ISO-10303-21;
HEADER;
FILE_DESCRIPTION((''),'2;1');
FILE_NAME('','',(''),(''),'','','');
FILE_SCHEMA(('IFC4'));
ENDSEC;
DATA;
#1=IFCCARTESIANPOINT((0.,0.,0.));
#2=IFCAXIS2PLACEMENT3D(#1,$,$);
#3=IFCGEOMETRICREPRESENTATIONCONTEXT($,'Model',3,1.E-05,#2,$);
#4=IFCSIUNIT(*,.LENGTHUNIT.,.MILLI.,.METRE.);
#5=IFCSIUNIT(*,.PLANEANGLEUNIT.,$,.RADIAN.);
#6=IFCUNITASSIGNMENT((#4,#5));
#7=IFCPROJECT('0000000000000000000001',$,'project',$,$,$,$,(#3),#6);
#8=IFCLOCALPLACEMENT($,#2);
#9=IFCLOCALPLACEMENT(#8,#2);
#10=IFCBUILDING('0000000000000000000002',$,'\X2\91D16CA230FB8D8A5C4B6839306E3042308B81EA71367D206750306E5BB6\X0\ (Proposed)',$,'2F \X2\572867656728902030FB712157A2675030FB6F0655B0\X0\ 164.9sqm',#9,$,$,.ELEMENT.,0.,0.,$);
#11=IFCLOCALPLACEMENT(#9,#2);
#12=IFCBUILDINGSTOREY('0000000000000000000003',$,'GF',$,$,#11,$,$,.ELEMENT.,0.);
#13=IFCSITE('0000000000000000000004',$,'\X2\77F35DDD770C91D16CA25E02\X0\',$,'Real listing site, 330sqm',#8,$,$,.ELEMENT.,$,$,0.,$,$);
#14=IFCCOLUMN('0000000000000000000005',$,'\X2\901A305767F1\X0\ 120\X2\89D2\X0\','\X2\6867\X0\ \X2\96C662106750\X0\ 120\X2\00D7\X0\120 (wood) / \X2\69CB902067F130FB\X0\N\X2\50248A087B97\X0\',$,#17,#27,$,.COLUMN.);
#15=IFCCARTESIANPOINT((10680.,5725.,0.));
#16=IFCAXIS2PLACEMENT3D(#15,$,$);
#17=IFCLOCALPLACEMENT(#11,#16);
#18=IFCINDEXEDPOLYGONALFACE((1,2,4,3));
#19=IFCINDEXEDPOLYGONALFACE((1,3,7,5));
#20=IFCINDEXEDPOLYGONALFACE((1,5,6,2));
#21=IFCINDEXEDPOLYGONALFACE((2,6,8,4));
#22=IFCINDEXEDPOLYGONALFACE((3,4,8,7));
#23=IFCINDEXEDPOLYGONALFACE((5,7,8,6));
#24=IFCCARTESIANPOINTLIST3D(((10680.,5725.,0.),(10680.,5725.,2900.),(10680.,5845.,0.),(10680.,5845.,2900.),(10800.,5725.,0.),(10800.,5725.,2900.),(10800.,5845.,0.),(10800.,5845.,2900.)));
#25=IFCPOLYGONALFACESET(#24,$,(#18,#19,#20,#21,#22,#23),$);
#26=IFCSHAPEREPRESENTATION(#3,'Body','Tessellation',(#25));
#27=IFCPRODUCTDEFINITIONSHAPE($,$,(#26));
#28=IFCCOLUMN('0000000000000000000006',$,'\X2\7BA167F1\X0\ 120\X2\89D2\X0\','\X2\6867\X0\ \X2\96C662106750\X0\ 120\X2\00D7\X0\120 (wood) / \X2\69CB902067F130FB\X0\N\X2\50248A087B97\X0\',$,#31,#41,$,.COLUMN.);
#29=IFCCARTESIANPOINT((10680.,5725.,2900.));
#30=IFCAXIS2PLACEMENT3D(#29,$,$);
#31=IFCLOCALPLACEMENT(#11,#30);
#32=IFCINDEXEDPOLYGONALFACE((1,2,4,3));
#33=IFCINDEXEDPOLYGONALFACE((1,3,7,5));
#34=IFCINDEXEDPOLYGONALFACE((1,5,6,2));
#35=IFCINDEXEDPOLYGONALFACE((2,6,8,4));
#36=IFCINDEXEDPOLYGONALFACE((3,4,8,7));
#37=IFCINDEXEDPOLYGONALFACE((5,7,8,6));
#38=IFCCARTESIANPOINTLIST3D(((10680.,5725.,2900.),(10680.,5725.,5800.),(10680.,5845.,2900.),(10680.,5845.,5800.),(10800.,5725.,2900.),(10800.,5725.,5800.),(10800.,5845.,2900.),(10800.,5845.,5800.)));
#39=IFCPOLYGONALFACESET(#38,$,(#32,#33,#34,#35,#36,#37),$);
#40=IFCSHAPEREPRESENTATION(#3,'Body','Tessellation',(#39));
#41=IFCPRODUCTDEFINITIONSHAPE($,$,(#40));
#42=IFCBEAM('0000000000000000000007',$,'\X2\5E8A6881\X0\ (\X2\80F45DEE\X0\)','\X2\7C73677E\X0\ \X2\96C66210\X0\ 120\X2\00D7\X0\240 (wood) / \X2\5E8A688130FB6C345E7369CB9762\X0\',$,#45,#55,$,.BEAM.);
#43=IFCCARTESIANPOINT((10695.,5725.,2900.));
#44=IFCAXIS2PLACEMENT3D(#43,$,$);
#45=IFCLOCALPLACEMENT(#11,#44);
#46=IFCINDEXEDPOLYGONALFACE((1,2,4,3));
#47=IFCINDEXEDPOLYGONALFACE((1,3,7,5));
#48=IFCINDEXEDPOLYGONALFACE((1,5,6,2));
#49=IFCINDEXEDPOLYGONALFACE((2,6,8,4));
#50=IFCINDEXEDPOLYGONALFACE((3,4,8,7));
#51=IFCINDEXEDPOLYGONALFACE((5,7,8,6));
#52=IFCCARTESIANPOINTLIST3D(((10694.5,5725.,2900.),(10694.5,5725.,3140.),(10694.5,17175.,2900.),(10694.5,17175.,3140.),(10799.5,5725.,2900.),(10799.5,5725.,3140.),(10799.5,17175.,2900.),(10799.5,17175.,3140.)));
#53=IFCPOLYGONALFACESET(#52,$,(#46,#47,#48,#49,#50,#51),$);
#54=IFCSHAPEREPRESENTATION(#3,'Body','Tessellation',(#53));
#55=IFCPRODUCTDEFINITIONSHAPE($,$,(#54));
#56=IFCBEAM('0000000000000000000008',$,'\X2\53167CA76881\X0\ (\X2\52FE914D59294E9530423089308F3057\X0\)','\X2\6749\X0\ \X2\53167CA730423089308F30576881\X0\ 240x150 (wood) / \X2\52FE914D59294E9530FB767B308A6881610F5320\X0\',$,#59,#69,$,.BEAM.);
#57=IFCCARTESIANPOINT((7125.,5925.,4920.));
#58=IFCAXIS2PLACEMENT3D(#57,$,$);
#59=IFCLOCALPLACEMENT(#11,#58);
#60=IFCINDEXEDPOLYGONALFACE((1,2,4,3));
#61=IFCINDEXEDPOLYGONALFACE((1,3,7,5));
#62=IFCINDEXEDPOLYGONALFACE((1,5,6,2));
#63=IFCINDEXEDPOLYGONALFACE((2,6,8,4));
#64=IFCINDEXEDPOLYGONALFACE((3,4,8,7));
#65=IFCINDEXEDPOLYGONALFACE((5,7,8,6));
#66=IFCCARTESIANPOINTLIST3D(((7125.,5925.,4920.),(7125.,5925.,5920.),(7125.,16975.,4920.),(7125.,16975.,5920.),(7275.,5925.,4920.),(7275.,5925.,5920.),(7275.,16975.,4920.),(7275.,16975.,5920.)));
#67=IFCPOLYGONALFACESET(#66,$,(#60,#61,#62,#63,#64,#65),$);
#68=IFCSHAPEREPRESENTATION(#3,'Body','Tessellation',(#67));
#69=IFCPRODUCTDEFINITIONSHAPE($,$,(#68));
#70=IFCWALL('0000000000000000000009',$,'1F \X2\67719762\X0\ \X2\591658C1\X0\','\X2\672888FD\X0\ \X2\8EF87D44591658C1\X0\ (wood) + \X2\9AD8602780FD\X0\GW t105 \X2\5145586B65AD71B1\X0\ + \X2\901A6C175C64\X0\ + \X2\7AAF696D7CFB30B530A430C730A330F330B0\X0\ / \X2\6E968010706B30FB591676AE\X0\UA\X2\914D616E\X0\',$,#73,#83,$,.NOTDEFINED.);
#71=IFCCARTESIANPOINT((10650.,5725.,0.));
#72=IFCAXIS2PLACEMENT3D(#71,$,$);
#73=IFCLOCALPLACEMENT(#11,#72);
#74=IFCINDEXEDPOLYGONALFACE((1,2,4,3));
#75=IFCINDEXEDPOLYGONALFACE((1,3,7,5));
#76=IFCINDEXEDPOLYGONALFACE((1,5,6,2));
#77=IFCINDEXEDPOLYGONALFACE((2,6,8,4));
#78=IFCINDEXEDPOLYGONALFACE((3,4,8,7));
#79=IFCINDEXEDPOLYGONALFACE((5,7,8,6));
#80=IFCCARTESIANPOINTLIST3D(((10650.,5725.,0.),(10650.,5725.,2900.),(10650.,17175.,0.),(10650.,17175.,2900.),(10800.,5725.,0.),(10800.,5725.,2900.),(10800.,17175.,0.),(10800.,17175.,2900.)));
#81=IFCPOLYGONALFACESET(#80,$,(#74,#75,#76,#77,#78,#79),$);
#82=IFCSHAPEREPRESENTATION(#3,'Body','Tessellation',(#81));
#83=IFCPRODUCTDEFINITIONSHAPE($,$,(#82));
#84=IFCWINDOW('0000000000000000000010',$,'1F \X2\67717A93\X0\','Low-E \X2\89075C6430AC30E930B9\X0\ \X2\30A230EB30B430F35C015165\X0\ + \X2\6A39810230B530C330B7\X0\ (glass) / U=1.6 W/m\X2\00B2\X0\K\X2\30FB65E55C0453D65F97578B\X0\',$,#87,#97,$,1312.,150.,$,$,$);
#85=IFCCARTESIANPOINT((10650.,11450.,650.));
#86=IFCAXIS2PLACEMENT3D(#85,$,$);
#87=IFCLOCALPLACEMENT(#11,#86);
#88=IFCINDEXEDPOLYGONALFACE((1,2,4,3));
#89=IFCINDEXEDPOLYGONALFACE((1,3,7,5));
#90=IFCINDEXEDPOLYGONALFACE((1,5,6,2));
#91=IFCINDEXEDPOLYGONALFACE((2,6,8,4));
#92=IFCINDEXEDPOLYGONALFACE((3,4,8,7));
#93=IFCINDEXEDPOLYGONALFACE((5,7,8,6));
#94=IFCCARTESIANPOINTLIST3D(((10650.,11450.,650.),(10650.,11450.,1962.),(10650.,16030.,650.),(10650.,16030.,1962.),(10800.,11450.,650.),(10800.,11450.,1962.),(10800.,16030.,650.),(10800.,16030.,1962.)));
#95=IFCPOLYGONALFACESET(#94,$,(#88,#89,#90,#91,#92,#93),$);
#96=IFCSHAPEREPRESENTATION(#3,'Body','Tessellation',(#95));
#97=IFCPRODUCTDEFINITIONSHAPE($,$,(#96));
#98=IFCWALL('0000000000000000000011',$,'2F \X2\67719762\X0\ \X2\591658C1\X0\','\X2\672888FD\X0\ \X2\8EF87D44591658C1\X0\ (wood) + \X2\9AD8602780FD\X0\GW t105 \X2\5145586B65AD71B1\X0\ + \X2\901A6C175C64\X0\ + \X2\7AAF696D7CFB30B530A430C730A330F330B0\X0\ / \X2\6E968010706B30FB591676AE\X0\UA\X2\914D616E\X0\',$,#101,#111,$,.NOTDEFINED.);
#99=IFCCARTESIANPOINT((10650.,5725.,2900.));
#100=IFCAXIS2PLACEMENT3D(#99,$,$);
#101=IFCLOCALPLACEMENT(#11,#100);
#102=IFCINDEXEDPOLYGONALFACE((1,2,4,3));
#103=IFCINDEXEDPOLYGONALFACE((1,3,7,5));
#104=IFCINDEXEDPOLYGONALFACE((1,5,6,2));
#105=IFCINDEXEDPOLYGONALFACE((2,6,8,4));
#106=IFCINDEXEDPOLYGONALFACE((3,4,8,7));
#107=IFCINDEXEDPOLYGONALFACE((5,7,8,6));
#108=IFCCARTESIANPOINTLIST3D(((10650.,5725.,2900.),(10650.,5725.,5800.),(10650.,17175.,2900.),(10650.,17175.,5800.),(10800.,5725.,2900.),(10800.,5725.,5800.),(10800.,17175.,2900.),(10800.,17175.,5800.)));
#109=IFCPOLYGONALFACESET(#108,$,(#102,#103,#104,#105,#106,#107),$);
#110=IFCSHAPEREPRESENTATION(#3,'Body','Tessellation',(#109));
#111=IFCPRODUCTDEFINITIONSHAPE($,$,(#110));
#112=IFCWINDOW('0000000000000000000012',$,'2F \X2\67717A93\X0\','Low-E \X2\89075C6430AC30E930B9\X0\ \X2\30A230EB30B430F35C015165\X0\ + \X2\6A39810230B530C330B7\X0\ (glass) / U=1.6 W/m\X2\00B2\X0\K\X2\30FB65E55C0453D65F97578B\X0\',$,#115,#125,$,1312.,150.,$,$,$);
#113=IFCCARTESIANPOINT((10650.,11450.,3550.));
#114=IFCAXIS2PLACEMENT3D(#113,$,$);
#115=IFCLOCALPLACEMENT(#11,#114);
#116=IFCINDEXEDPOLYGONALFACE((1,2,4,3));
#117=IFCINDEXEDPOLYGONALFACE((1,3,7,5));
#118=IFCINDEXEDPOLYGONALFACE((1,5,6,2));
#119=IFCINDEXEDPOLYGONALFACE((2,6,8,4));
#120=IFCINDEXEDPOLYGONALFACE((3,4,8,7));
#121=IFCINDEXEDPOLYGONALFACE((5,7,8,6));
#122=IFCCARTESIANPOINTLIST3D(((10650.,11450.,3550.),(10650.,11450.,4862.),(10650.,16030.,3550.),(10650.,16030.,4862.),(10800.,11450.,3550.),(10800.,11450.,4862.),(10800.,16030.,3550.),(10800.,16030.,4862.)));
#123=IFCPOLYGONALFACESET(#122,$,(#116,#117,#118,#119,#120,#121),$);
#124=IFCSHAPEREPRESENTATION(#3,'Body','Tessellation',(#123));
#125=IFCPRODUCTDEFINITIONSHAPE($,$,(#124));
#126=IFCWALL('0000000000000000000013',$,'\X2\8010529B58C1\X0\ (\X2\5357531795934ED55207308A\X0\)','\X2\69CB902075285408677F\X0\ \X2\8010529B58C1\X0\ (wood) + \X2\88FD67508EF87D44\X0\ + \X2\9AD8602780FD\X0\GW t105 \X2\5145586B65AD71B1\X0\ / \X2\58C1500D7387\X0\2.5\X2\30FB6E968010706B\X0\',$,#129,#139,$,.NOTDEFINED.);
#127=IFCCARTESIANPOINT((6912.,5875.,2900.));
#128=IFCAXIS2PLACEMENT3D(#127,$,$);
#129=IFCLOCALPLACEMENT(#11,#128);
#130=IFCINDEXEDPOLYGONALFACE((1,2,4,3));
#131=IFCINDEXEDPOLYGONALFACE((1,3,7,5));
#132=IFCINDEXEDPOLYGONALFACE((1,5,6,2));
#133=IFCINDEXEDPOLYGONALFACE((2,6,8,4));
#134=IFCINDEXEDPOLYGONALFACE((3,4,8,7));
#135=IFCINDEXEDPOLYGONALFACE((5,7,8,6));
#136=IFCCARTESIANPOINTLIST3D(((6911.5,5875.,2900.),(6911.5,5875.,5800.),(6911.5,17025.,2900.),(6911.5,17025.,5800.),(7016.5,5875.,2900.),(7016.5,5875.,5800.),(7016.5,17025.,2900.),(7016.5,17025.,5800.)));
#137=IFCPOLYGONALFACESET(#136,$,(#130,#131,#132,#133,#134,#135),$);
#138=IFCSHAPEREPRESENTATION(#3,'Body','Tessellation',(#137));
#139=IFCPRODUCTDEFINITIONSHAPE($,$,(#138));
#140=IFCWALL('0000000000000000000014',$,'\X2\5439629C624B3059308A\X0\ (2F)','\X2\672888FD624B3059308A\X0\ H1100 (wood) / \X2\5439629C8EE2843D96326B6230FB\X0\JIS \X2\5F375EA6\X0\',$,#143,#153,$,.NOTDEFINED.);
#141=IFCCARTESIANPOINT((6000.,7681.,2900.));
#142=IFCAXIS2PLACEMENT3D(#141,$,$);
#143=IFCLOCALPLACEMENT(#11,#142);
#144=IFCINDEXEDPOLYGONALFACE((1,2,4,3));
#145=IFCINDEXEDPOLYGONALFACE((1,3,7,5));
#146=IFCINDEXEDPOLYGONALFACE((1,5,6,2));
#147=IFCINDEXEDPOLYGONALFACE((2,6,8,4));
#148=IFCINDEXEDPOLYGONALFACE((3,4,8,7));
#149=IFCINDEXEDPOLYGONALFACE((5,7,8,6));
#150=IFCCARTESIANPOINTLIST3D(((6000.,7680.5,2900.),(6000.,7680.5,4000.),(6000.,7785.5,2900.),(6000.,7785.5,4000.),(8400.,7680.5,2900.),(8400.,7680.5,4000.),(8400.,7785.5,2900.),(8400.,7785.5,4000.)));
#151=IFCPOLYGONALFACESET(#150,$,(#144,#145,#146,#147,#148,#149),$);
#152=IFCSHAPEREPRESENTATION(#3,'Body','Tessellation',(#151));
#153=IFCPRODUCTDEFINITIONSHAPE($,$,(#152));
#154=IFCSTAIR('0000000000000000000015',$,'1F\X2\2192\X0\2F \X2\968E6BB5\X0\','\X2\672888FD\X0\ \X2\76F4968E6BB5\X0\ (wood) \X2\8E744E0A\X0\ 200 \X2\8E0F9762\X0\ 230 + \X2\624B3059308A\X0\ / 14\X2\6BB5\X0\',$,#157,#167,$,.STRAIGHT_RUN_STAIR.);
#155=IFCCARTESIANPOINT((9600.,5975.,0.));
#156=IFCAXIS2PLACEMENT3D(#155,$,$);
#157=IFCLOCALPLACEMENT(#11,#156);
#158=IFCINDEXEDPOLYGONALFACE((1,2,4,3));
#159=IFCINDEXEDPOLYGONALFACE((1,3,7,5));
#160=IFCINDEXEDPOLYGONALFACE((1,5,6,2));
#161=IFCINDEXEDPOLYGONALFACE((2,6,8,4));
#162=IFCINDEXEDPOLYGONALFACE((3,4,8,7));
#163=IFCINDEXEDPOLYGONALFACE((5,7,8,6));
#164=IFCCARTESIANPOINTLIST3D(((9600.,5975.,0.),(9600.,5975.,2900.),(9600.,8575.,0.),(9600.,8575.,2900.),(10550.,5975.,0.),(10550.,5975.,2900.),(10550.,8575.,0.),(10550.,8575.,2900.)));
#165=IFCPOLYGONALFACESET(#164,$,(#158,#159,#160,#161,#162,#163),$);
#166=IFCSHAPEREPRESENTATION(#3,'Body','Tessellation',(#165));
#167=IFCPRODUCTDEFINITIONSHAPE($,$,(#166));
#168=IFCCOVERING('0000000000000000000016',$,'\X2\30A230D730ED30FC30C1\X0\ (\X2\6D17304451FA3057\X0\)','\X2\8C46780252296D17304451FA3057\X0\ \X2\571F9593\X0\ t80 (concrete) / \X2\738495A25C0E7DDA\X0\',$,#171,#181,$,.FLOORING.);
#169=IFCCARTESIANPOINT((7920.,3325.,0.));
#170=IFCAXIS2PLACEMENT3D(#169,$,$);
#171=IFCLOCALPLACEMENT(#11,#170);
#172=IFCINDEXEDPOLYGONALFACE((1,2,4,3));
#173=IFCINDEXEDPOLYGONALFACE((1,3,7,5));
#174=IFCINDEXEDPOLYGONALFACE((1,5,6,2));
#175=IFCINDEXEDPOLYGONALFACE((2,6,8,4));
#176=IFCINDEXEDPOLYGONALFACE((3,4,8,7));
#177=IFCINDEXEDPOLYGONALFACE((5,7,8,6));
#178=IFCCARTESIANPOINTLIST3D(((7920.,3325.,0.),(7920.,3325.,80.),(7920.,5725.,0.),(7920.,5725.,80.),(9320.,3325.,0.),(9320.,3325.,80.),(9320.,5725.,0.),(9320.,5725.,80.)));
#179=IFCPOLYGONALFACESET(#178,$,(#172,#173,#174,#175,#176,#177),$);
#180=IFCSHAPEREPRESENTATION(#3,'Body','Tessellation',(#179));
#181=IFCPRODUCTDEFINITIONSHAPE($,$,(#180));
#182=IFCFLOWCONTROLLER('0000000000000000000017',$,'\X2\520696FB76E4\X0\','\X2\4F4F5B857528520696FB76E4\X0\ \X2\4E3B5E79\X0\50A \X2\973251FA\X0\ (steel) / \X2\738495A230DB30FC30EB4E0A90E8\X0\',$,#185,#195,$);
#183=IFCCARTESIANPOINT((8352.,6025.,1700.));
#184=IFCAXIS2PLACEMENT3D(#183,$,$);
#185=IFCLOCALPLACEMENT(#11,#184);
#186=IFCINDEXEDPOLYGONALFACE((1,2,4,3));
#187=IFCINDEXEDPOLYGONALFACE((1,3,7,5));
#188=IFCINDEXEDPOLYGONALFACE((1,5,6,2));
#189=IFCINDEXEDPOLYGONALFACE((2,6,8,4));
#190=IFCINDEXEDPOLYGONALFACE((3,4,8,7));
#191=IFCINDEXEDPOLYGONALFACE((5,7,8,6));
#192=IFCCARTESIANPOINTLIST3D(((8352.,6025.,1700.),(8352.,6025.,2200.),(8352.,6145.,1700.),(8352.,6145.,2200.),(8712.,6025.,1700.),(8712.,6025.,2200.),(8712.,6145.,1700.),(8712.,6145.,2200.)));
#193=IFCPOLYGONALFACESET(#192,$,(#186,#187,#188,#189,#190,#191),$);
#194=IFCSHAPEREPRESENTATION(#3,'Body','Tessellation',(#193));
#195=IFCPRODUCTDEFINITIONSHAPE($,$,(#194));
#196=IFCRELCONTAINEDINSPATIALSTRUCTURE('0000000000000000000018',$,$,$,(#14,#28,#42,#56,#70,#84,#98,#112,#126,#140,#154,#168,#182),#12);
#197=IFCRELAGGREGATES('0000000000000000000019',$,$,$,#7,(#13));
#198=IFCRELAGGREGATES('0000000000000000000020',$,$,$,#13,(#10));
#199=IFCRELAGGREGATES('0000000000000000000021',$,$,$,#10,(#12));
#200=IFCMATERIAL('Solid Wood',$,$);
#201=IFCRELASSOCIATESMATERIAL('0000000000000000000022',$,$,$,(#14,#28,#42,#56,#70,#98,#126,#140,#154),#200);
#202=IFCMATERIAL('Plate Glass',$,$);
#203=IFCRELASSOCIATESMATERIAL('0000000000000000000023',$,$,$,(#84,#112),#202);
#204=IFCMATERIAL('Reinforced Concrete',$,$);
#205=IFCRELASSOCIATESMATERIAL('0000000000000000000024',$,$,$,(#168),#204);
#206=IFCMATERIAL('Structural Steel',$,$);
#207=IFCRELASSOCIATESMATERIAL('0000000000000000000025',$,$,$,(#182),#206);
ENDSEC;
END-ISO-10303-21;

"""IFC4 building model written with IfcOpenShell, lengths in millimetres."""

from ifc_helpers import new_model, si_unit, frame, frame_2d, origin, place, context, project, spatial, rectangle, extrude, material, element, fill, save


model = new_model("IFC4")

# Units and contexts
model_context = context("Model", 3, precision=1e-05, world=origin())
ifc_project = project(units=[si_unit("LENGTHUNIT", "METRE", prefix="MILLI"), si_unit("PLANEANGLEUNIT", "RADIAN")], contexts=[model_context])

# Site, building, storey
site_placement = place(None, origin())
site = spatial("IfcSite", under=ifc_project, at=site_placement, Name="石川県金沢市", ObjectType="Real listing site, 330sqm", CompositionType="ELEMENT", RefElevation=0.0)
building_placement = place(site_placement, origin())
building = spatial("IfcBuilding", under=site, at=building_placement, Name="金沢・越屋根のある自然素材の家 (Proposed)", ObjectType="2F 在来木造・無垢材・漆喰 164.9sqm", CompositionType="ELEMENT", ElevationOfRefHeight=0.0, ElevationOfTerrain=0.0)
storey_placement = place(building_placement, origin())
storey = spatial("IfcBuildingStorey", under=building, at=storey_placement, Name="GF", CompositionType="ELEMENT", Elevation=0.0)

# Columns
ifc_material_1 = material(Name="Solid Wood")
column_1_placement = place(storey_placement, frame((10680.0, 5725.0, 0.0)))
element("IfcColumn", 1, at=column_1_placement, inside=storey, material=ifc_material_1, Name="通し柱 120角", Description="桧 集成材 120×120 (wood) / 構造柱・N値計算", PredefinedType="COLUMN", context=model_context, shape_type="SweptSolid", body=[
    extrude(rectangle(XDim=120.0, YDim=120.0, at=frame_2d((60.0, 60.0))), frame((10680.0, 5725.0, 0.0)), (0.0, 0.0, 1.0), 2900.0),
])
column_2_placement = place(storey_placement, frame((10680.0, 5725.0, 2900.0)))
element("IfcColumn", 2, at=column_2_placement, inside=storey, material=ifc_material_1, Name="管柱 120角", Description="桧 集成材 120×120 (wood) / 構造柱・N値計算", PredefinedType="COLUMN", context=model_context, shape_type="SweptSolid", body=[
    extrude(rectangle(XDim=120.0, YDim=120.0, at=frame_2d((60.0, 60.0))), frame((10680.0, 5725.0, 2900.0)), (0.0, 0.0, 1.0), 2900.0),
])

# Beams
beam_1_placement = place(storey_placement, frame((10695.0, 5725.0, 2900.0)))
element("IfcBeam", 3, at=beam_1_placement, inside=storey, material=ifc_material_1, Name="床梁 (胴差)", Description="米松 集成 120×240 (wood) / 床梁・水平構面", PredefinedType="BEAM", context=model_context, shape_type="SweptSolid", body=[
    extrude(rectangle(XDim=105.0, YDim=11450.0, at=frame_2d((52.0, 5725.0))), frame((10695.0, 5725.0, 2900.0)), (0.0, 0.0, 1.0), 240.0),
])
beam_2_placement = place(storey_placement, frame((7125.0, 5925.0, 4920.0)))
element("IfcBeam", 4, at=beam_2_placement, inside=storey, material=ifc_material_1, Name="化粧梁 (勾配天井あらわし)", Description="杉 化粧あらわし梁 240x150 (wood) / 勾配天井・登り梁意匠", PredefinedType="BEAM", context=model_context, shape_type="SweptSolid", body=[
    extrude(rectangle(XDim=150.0, YDim=11050.0, at=frame_2d((75.0, 5525.0))), frame((7125.0, 5925.0, 4920.0)), (0.0, 0.0, 1.0), 1000.0),
])

# Wall, opening, window
wall_1_placement = place(storey_placement, frame((10650.0, 5725.0, 0.0)))
wall_1 = element("IfcWall", 5, at=wall_1_placement, inside=storey, material=ifc_material_1, Name="1F 東面 外壁", Description="木製 軸組外壁 (wood) + 高性能GW t105 充填断熱 + 通気層 + 窯業系サイディング / 準耐火・外皮UA配慮", PredefinedType="NOTDEFINED", context=model_context, shape_type="SweptSolid", body=[
    extrude(rectangle(XDim=150.0, YDim=11450.0, at=frame_2d((75.0, 5725.0))), frame((10650.0, 5725.0, 0.0)), (0.0, 0.0, 1.0), 2900.0),
])
opening_1_placement = place(storey_placement, frame((10650.0, 11450.0, 650.0)))
opening_1 = element("IfcOpeningElement", 6, at=opening_1_placement, cuts=wall_1, PredefinedType="NOTDEFINED", context=model_context, shape_type="SweptSolid", body=[
    extrude(rectangle(XDim=150.0, YDim=4580.0, at=frame_2d((75.0, 2290.0))), frame((10650.0, 11450.0, 650.0)), (0.0, 0.0, 1.0), 1312.0),
])
ifc_material_2 = material(Name="Plate Glass")
window_1_placement = place(storey_placement, frame((10650.0, 11450.0, 650.0)))
window_1 = element("IfcWindow", 7, at=window_1_placement, inside=storey, material=ifc_material_2, Name="1F 東窓", Description="Low-E 複層ガラス アルゴン封入 + 樹脂サッシ (glass) / U=1.6 W/m²K・日射取得型", OverallHeight=1312.0, OverallWidth=150.0, context=model_context, shape_type="SweptSolid", body=[
    extrude(rectangle(XDim=150.0, YDim=4580.0, at=frame_2d((75.0, 2290.0))), frame((10650.0, 11450.0, 650.0)), (0.0, 0.0, 1.0), 1312.0),
])
fill(opening_1, window_1)

# Wall, opening, window
wall_2_placement = place(storey_placement, frame((10650.0, 5725.0, 2900.0)))
wall_2 = element("IfcWall", 8, at=wall_2_placement, inside=storey, material=ifc_material_1, Name="2F 東面 外壁", Description="木製 軸組外壁 (wood) + 高性能GW t105 充填断熱 + 通気層 + 窯業系サイディング / 準耐火・外皮UA配慮", PredefinedType="NOTDEFINED", context=model_context, shape_type="SweptSolid", body=[
    extrude(rectangle(XDim=150.0, YDim=11450.0, at=frame_2d((75.0, 5725.0))), frame((10650.0, 5725.0, 2900.0)), (0.0, 0.0, 1.0), 2900.0),
])
opening_2_placement = place(storey_placement, frame((10650.0, 11450.0, 3550.0)))
opening_2 = element("IfcOpeningElement", 9, at=opening_2_placement, cuts=wall_2, PredefinedType="NOTDEFINED", context=model_context, shape_type="SweptSolid", body=[
    extrude(rectangle(XDim=150.0, YDim=4580.0, at=frame_2d((75.0, 2290.0))), frame((10650.0, 11450.0, 3550.0)), (0.0, 0.0, 1.0), 1312.0),
])
window_2_placement = place(storey_placement, frame((10650.0, 11450.0, 3550.0)))
window_2 = element("IfcWindow", 10, at=window_2_placement, inside=storey, material=ifc_material_2, Name="2F 東窓", Description="Low-E 複層ガラス アルゴン封入 + 樹脂サッシ (glass) / U=1.6 W/m²K・日射取得型", OverallHeight=1312.0, OverallWidth=150.0, context=model_context, shape_type="SweptSolid", body=[
    extrude(rectangle(XDim=150.0, YDim=4580.0, at=frame_2d((75.0, 2290.0))), frame((10650.0, 11450.0, 3550.0)), (0.0, 0.0, 1.0), 1312.0),
])
fill(opening_2, window_2)

# Walls
wall_3_placement = place(storey_placement, frame((6912.0, 5875.0, 2900.0)))
element("IfcWall", 11, at=wall_3_placement, inside=storey, material=ifc_material_1, Name="耐力壁 (南北間仕切り)", Description="構造用合板 耐力壁 (wood) + 製材軸組 + 高性能GW t105 充填断熱 / 壁倍率2.5・準耐火", PredefinedType="NOTDEFINED", context=model_context, shape_type="SweptSolid", body=[
    extrude(rectangle(XDim=105.0, YDim=11150.0, at=frame_2d((52.0, 5575.0))), frame((6912.0, 5875.0, 2900.0)), (0.0, 0.0, 1.0), 2900.0),
])
wall_4_placement = place(storey_placement, frame((6000.0, 7681.0, 2900.0)))
element("IfcWall", 12, at=wall_4_placement, inside=storey, material=ifc_material_1, Name="吹抜手すり (2F)", Description="木製手すり H1100 (wood) / 吹抜転落防止・JIS 強度", PredefinedType="NOTDEFINED", context=model_context, shape_type="SweptSolid", body=[
    extrude(rectangle(XDim=2400.0, YDim=105.0, at=frame_2d((1200.0, 52.0))), frame((6000.0, 7681.0, 2900.0)), (0.0, 0.0, 1.0), 1100.0),
])

# Stair
stair_placement = place(storey_placement, frame((9600.0, 5975.0, 0.0)))
element("IfcStair", 13, at=stair_placement, inside=storey, material=ifc_material_1, Name="1F→2F 階段", Description="木製 直階段 (wood) 蹴上 200 踏面 230 + 手すり / 14段", PredefinedType="STRAIGHT_RUN_STAIR", context=model_context, shape_type="SweptSolid", body=[
    extrude(rectangle(XDim=950.0, YDim=2600.0, at=frame_2d((475.0, 1300.0))), frame((9600.0, 5975.0, 0.0)), (0.0, 0.0, 1.0), 2900.0),
])

# Covering
ifc_material_3 = material(Name="Reinforced Concrete")
covering_placement = place(storey_placement, frame((7920.0, 3325.0, 0.0)))
element("IfcCovering", 14, at=covering_placement, inside=storey, material=ifc_material_3, Name="アプローチ (洗い出し)", Description="豆砂利洗い出し 土間 t80 (concrete) / 玄関導線", PredefinedType="FLOORING", context=model_context, shape_type="SweptSolid", body=[
    extrude(rectangle(XDim=1400.0, YDim=2400.0, at=frame_2d((700.0, 1200.0))), frame((7920.0, 3325.0, 0.0)), (0.0, 0.0, 1.0), 80.0),
])

# Flow controller
ifc_material_4 = material(Name="Structural Steel")
flow_controller_placement = place(storey_placement, frame((8352.0, 6025.0, 1700.0)))
element("IfcFlowController", 15, at=flow_controller_placement, inside=storey, material=ifc_material_4, Name="分電盤", Description="住宅用分電盤 主幹50A 露出 (steel) / 玄関ホール上部", context=model_context, shape_type="SweptSolid", body=[
    extrude(rectangle(XDim=360.0, YDim=120.0, at=frame_2d((180.0, 60.0))), frame((8352.0, 6025.0, 1700.0)), (0.0, 0.0, 1.0), 500.0),
])

save(model, "model.ifc")
